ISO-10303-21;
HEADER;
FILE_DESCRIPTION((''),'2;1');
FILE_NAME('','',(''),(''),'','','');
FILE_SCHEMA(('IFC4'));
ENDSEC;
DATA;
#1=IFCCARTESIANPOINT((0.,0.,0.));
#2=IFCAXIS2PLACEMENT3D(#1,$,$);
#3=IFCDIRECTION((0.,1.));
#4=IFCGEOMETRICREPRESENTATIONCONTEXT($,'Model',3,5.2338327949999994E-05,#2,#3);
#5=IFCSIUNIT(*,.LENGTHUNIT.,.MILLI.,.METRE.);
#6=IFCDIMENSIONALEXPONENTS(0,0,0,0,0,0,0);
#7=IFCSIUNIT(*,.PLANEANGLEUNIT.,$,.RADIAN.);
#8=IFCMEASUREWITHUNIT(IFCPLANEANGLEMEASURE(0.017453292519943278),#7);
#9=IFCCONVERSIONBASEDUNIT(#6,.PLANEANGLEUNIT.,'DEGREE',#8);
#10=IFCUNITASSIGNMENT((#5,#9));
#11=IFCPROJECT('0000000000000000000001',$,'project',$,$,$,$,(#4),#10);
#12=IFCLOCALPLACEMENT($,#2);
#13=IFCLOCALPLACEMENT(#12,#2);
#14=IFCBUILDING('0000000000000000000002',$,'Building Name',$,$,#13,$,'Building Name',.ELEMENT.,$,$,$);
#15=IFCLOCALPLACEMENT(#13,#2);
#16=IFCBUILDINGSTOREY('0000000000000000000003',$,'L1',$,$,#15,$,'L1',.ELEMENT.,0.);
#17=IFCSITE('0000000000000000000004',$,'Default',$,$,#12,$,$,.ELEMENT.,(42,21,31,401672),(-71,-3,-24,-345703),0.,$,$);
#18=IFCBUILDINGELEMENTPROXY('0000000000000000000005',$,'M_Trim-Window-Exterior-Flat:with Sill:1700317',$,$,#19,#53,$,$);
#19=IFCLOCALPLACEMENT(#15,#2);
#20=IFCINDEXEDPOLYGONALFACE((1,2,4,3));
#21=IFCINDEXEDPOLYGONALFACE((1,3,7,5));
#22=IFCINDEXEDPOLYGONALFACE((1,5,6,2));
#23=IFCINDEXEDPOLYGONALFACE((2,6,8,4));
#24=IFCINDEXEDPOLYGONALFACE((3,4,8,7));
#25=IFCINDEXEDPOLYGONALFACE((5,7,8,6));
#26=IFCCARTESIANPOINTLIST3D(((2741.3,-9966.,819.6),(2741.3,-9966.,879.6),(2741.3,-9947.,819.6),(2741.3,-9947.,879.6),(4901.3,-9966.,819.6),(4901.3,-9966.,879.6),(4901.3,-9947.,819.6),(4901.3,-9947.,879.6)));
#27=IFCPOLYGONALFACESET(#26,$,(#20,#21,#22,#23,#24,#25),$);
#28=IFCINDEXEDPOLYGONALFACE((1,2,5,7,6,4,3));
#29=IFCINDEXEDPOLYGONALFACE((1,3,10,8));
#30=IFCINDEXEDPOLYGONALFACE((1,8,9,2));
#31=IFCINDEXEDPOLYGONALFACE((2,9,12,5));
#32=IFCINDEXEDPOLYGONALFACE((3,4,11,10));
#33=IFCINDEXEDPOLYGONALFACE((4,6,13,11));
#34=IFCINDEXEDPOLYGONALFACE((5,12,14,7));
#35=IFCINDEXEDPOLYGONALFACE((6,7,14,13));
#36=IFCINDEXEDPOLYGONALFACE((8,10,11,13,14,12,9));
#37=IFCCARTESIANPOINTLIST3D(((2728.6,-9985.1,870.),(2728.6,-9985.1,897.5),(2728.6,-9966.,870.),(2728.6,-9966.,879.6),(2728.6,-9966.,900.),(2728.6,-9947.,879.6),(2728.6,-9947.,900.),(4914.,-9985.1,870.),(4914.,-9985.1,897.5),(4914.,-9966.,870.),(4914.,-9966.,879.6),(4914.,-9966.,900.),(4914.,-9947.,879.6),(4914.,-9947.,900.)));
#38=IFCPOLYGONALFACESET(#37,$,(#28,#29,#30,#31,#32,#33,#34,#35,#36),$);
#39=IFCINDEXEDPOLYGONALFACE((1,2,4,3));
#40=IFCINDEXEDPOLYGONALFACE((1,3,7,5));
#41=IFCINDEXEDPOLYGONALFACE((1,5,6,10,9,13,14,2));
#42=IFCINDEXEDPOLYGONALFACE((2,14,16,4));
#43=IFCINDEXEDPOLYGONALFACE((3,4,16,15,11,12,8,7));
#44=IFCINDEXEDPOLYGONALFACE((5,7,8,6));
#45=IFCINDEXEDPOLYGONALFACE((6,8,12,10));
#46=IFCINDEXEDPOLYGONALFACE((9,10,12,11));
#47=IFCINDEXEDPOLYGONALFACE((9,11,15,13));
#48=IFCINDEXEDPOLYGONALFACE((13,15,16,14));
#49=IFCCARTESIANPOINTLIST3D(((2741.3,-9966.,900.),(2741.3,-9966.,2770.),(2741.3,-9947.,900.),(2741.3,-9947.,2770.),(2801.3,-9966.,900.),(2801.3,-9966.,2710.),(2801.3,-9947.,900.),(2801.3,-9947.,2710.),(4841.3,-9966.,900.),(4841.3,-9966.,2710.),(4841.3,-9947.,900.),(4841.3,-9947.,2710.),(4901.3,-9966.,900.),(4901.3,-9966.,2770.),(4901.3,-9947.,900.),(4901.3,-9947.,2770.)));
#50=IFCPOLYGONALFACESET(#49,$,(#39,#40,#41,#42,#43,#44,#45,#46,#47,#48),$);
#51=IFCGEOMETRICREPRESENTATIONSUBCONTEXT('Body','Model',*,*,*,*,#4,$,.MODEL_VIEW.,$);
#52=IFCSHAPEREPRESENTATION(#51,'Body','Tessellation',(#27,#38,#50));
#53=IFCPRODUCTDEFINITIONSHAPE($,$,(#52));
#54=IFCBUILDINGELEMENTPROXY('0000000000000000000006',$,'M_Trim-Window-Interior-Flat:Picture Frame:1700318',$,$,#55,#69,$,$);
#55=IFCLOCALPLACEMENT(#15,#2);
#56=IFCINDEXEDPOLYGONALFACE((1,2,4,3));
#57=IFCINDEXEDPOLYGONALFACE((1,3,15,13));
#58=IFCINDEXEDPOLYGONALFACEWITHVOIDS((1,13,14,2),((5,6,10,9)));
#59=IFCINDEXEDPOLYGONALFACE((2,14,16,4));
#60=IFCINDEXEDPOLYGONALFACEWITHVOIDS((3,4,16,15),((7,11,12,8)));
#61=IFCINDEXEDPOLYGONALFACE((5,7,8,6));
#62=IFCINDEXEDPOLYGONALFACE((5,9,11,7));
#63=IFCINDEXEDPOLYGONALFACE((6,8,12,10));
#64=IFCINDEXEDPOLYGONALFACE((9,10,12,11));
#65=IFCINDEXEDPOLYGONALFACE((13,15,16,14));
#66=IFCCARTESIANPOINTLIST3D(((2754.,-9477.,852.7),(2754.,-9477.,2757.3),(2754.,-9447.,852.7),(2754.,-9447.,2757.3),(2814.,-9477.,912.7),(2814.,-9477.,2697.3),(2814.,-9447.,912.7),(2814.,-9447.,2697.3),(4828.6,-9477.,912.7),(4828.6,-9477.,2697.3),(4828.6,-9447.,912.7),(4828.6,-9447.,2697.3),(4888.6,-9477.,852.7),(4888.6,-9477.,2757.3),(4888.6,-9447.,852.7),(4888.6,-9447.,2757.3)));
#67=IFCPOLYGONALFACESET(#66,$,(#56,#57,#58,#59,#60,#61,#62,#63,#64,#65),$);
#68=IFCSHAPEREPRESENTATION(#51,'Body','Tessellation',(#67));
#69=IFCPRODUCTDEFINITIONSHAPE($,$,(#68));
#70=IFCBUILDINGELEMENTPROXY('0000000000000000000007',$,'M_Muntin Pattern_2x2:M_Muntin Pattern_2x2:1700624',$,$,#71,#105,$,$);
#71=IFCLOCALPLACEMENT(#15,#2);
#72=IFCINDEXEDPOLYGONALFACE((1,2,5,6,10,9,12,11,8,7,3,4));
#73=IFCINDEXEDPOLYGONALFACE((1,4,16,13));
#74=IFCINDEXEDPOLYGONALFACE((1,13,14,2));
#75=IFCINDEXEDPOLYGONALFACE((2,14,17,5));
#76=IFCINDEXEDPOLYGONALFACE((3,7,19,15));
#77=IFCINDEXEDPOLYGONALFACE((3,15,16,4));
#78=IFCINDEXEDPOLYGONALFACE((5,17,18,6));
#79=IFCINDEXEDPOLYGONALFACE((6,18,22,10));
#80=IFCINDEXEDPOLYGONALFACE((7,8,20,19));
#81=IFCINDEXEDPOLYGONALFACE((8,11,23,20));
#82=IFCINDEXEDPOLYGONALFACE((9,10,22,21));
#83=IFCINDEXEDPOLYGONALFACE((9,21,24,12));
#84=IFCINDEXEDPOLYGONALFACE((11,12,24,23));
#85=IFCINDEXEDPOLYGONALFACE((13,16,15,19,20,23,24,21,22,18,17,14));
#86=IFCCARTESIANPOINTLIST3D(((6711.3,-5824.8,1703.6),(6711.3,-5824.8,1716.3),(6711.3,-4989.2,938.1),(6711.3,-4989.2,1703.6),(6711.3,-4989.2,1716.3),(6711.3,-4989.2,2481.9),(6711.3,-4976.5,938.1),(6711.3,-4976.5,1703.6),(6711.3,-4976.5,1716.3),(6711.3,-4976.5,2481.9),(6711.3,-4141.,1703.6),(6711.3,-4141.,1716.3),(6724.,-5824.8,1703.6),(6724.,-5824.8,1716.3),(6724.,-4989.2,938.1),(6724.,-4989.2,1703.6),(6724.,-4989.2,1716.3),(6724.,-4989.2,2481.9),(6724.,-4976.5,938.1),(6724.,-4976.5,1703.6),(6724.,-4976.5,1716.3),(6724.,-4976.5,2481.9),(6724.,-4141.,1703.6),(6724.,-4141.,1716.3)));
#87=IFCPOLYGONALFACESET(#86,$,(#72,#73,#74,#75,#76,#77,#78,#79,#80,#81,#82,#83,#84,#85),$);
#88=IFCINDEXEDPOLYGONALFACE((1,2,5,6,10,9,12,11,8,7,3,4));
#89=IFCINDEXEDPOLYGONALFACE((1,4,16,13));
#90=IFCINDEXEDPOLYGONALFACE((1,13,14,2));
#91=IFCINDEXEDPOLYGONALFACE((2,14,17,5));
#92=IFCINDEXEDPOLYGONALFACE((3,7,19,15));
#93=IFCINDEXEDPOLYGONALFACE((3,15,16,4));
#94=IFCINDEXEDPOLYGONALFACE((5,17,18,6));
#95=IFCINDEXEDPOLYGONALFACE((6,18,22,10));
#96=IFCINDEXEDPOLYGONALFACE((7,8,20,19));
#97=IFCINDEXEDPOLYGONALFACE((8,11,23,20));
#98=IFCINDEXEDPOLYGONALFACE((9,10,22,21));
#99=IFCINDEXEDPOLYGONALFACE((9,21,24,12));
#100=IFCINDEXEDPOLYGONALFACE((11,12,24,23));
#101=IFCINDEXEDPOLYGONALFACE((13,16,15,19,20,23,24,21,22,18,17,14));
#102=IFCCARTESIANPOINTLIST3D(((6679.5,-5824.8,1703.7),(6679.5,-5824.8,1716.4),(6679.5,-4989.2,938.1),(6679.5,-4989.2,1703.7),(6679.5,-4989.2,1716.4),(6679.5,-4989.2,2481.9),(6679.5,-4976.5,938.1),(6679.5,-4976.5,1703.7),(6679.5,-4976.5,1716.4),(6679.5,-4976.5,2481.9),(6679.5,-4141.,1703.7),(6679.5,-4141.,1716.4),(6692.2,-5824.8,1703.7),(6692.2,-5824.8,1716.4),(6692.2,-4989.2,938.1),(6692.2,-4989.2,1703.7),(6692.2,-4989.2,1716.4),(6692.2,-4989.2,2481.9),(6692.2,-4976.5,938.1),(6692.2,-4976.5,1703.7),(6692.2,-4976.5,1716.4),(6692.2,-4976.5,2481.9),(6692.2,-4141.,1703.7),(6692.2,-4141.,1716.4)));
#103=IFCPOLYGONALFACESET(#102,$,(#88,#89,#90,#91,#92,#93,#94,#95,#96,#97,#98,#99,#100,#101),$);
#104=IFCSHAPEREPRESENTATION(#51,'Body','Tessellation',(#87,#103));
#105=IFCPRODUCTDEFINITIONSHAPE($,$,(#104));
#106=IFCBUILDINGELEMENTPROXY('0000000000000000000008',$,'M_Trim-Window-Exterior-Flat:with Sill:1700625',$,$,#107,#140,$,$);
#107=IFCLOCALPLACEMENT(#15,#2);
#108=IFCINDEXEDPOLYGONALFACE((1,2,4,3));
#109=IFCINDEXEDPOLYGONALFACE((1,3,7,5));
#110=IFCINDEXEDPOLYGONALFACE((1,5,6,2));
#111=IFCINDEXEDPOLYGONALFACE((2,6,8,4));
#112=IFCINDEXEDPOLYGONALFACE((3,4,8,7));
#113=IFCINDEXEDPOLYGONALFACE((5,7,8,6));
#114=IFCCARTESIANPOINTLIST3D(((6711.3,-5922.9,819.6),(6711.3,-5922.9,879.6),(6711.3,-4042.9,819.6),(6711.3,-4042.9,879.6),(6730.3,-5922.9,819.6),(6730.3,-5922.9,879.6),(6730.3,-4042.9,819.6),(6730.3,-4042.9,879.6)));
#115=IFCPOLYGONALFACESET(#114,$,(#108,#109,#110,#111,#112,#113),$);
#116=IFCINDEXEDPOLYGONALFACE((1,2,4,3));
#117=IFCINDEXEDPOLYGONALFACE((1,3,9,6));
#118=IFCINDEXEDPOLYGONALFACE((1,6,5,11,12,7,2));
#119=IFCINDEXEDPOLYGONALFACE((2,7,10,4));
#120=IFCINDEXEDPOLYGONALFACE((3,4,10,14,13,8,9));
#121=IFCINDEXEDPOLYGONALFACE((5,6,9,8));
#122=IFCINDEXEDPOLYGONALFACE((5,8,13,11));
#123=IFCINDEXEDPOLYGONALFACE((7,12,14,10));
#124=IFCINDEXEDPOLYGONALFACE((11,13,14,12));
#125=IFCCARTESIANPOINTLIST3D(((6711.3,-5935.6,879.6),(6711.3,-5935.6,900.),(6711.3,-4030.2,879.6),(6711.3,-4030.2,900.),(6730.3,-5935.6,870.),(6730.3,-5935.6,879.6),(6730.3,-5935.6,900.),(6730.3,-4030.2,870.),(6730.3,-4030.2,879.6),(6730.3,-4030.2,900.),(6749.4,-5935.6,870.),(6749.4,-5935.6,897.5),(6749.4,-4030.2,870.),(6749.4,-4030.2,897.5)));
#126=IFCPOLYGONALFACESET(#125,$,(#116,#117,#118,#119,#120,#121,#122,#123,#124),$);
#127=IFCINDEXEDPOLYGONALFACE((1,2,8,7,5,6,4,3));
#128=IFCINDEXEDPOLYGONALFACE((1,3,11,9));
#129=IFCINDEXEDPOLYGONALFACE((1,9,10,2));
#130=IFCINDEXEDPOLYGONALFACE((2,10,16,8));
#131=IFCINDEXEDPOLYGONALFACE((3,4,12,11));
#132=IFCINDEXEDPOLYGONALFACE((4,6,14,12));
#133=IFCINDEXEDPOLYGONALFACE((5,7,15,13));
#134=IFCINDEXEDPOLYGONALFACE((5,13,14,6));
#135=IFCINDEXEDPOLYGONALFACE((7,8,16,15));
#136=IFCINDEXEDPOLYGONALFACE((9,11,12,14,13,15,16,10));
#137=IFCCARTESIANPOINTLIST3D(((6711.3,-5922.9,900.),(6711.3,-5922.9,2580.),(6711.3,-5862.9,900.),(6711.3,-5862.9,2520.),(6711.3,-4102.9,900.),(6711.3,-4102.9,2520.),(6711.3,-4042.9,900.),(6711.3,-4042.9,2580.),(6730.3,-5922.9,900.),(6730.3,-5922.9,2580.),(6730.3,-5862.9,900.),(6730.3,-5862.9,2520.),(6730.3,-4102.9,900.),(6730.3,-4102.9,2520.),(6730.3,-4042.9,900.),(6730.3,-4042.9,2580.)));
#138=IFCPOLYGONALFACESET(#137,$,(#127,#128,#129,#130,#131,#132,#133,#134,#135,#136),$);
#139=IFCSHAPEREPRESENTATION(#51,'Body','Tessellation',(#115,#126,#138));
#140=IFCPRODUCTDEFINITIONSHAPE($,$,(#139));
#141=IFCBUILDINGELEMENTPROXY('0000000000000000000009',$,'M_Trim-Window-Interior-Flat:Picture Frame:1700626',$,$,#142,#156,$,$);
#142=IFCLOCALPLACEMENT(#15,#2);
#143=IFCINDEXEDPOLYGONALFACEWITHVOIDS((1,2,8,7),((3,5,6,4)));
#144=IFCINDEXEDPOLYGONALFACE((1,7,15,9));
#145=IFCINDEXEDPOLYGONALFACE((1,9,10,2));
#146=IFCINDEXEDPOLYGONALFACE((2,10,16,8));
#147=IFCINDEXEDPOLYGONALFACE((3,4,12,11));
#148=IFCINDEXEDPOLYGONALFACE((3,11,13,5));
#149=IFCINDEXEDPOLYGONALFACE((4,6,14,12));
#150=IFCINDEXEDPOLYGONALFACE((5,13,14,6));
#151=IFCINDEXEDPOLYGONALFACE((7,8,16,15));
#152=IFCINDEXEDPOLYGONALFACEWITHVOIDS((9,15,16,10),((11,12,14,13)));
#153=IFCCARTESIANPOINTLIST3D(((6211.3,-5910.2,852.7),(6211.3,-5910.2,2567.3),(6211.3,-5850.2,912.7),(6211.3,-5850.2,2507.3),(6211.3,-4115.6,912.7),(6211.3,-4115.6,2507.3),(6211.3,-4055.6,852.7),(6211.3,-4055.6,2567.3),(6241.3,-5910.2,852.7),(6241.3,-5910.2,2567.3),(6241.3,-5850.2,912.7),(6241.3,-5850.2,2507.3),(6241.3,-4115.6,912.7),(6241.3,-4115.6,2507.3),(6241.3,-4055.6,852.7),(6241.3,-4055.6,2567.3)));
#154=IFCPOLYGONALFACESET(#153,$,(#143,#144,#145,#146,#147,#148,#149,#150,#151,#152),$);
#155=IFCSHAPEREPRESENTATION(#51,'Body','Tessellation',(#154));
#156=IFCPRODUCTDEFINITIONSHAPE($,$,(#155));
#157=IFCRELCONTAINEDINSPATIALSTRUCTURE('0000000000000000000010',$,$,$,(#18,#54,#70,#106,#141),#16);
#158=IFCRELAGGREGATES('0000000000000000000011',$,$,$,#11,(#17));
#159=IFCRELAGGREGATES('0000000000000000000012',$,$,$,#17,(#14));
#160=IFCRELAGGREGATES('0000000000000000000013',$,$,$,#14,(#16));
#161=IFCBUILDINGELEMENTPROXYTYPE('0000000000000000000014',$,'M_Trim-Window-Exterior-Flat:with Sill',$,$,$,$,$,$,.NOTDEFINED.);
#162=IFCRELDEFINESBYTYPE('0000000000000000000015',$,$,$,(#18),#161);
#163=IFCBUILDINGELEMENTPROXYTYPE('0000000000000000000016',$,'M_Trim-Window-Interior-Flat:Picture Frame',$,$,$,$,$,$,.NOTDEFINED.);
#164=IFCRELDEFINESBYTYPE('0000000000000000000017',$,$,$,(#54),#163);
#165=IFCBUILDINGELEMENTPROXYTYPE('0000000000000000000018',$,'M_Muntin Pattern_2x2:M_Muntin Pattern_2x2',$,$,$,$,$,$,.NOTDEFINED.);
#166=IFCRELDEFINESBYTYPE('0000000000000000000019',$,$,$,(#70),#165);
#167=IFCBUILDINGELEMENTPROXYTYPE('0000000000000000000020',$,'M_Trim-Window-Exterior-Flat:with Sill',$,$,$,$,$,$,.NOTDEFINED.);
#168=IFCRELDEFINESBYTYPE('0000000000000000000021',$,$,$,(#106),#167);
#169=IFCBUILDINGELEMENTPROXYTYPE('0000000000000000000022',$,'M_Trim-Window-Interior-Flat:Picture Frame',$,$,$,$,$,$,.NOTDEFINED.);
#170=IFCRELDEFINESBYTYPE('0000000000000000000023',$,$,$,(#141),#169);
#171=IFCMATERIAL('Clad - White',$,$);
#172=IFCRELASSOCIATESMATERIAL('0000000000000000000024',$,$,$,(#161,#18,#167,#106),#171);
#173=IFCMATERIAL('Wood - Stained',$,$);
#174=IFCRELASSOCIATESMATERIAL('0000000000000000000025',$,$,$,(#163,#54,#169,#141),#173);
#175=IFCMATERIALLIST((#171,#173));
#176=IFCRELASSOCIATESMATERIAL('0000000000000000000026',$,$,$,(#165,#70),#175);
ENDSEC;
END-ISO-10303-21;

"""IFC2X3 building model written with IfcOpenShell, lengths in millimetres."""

from ifc_helpers import new_model, entity, si_unit, converted_unit, direction, frame, frame_2d, origin, origin_2d_with_axis, place, context, subcontext, project, spatial, polyline, rectangle, outline, extrude, source, transform, mapped, material, material_list, type_object, type_shapes, element, save


model = new_model("IFC2X3")

# Units and contexts
model_context = context("Model", 3, precision=5.2338327949999994e-05, world=origin(), true_north=direction((0.0, 1.0)))
body_context = subcontext(model_context, "Body", "Model", "MODEL_VIEW")
ifc_project = project(units=[si_unit("LENGTHUNIT", "METRE", prefix="MILLI"), converted_unit("PLANEANGLEUNIT", "DEGREE", entity("IfcPlaneAngleMeasure", 0.017453292519943278), si_unit("PLANEANGLEUNIT", "RADIAN"), dimensions=[0, 0, 0, 0, 0, 0, 0])], contexts=[model_context])

# Site, building, storey
site_placement = place(None, origin())
site = spatial("IfcSite", under=ifc_project, at=site_placement, Name="Default", CompositionType="ELEMENT", RefLatitude=(42, 21, 31, 401672), RefLongitude=(-71, -3, -24, -345703), RefElevation=0.0)
building_placement = place(site_placement, origin())
building = spatial("IfcBuilding", under=site, at=building_placement, Name="Building Name", LongName="Building Name", CompositionType="ELEMENT")
storey_placement = place(building_placement, origin())
storey = spatial("IfcBuildingStorey", under=building, at=storey_placement, Name="L1", LongName="L1", CompositionType="ELEMENT", Elevation=0.0)

# Building element proxies
ifc_material_1 = material(Name="Clad - White")
ifc_material_2 = material(Name="Wood - Stained")
ifc_material_list = material_list([ifc_material_1, ifc_material_2])
building_element_proxy_type_1 = type_object("IfcBuildingElementProxyType", Name="M_Trim-Window-Exterior-Flat:with Sill", PredefinedType="NOTDEFINED", material=ifc_material_1)
shared_shape_1 = source(origin(), body_context, "Body", "SweptSolid", [
    extrude(rectangle(XDim=2160.0, YDim=60.0, at=frame_2d((0.0, 0.0), x_axis=(1.0, 0.0))), frame((0.0, -1860.4, 0.0), z_axis=(0.0, 0.0, 1.0), x_axis=(-1.0, 0.0, 0.0)), (0.0, 0.0, 1.0), 19.0),
    extrude(outline(polyline([(-19.0, -15.2), (0.0, -15.2), (0.0, -5.7), (19.0, -5.7), (19.0, 14.8), (0.0, 14.8), (-19.0, 12.3), (-19.0, -15.2)])), frame((-1092.7, -1824.8, 19.0), z_axis=(1.0, 0.0, 0.0), x_axis=(0.0, 0.0, -1.0)), (0.0, 0.0, 1.0), 2185.4),
    extrude(outline(polyline([(-950.0, -1080.0), (920.0, -1080.0), (920.0, -1020.0), (-890.0, -1020.0), (-890.0, 1020.0), (920.0, 1020.0), (920.0, 1080.0), (-950.0, 1080.0), (-950.0, -1080.0)])), frame((0.0, -890.0, 0.0), z_axis=(0.0, 0.0, 1.0), x_axis=(0.0, -1.0, 0.0)), (0.0, 0.0, 1.0), 19.0),
])
type_shapes(building_element_proxy_type_1, [shared_shape_1])
proxy_1_placement = place(storey_placement, frame((3821.3, -9947.0, 2710.0), z_axis=(0.0, -1.0, 0.0), x_axis=(1.0, 0.0, 0.0)))
element("IfcBuildingElementProxy", 1, at=proxy_1_placement, inside=storey, type_object=building_element_proxy_type_1, material=ifc_material_1, Name="M_Trim-Window-Exterior-Flat:with Sill:1700317", context=body_context, shape_type="MappedRepresentation", body=[
    mapped(shared_shape_1, transform((0.0, 0.0, 0.0), scale=1.0)),
])
building_element_proxy_type_2 = type_object("IfcBuildingElementProxyType", Name="M_Trim-Window-Interior-Flat:Picture Frame", PredefinedType="NOTDEFINED", material=ifc_material_2)
shared_shape_2 = source(origin(), body_context, "Body", "SweptSolid", [
    extrude(outline(polyline([(-1067.3, -952.3), (1067.3, -952.3), (1067.3, 952.3), (-1067.3, 952.3), (-1067.3, -952.3)]), holes=[polyline([(-1007.3, -892.3), (-1007.3, 892.3), (1007.3, 892.3), (1007.3, -892.3), (-1007.3, -892.3)])]), frame((0.0, -905.0, 0.0), z_axis=(0.0, 0.0, 1.0), x_axis=(-1.0, 0.0, 0.0)), (0.0, 0.0, 1.0), 30.0),
])
type_shapes(building_element_proxy_type_2, [shared_shape_2])
proxy_2_placement = place(storey_placement, frame((3821.3, -9477.0, 2710.0), z_axis=(0.0, 1.0, 0.0), x_axis=(-1.0, 0.0, 0.0)))
element("IfcBuildingElementProxy", 2, at=proxy_2_placement, inside=storey, type_object=building_element_proxy_type_2, material=ifc_material_2, Name="M_Trim-Window-Interior-Flat:Picture Frame:1700318", context=body_context, shape_type="MappedRepresentation", body=[
    mapped(shared_shape_2, transform((0.0, 0.0, 0.0), scale=1.0)),
])
building_element_proxy_type_3 = type_object("IfcBuildingElementProxyType", Name="M_Muntin Pattern_2x2:M_Muntin Pattern_2x2", PredefinedType="NOTDEFINED", material=ifc_material_list)
shared_shape_3 = source(origin(), body_context, "Body", "SweptSolid", [
    extrude(outline(polyline([(6.4, -6.4), (771.9, -6.4), (771.9, 6.3), (6.4, 6.3), (6.4, 841.9), (-6.3, 841.9), (-6.3, 6.3), (-771.9, 6.3), (-771.9, -6.4), (-6.3, -6.4), (-6.3, -841.9), (6.4, -841.9), (6.4, -6.4)])), frame((0.0, -22.2, 771.9), z_axis=(0.0, 1.0, 0.0), x_axis=(0.0, 0.0, 1.0)), (0.0, 0.0, 1.0), 12.7),
    extrude(outline(polyline([(6.4, -6.4), (771.9, -6.4), (771.9, 6.3), (6.4, 6.3), (6.4, 841.9), (-6.3, 841.9), (-6.3, 6.3), (-771.9, 6.3), (-771.9, -6.4), (-6.3, -6.4), (-6.3, -841.9), (6.4, -841.9), (6.4, -6.4)])), frame((0.0, 9.5, 771.9), z_axis=(0.0, 1.0, 0.0), x_axis=(0.0, 0.0, 1.0)), (0.0, 0.0, 1.0), 12.7),
])
type_shapes(building_element_proxy_type_3, [shared_shape_3])
proxy_3_placement = place(storey_placement, frame((6701.7, -4982.9, 938.1), z_axis=(0.0, 0.0, 1.0), x_axis=(0.0, 1.0, 0.0)))
element("IfcBuildingElementProxy", 3, at=proxy_3_placement, inside=storey, type_object=building_element_proxy_type_3, material=ifc_material_list, Name="M_Muntin Pattern_2x2:M_Muntin Pattern_2x2:1700624", context=body_context, shape_type="MappedRepresentation", body=[
    mapped(shared_shape_3, transform((0.0, 0.0, 0.0), scale=1.0)),
])
building_element_proxy_type_4 = type_object("IfcBuildingElementProxyType", Name="M_Trim-Window-Exterior-Flat:with Sill", PredefinedType="NOTDEFINED", material=ifc_material_1)
shared_shape_4 = source(origin(), body_context, "Body", "SweptSolid", [
    extrude(rectangle(XDim=1880.0, YDim=60.0, at=origin_2d_with_axis()), frame((0.0, -1670.4, 0.0), z_axis=(0.0, 0.0, 1.0), x_axis=(-1.0, 0.0, 0.0)), (0.0, 0.0, 1.0), 19.0),
    extrude(outline(polyline([(-19.0, -15.2), (0.0, -15.2), (0.0, -5.7), (19.0, -5.7), (19.0, 14.8), (0.0, 14.8), (-19.0, 12.3), (-19.0, -15.2)])), frame((-952.7, -1634.8, 19.0), z_axis=(1.0, 0.0, 0.0), x_axis=(0.0, 0.0, -1.0)), (0.0, 0.0, 1.0), 1905.4),
    extrude(outline(polyline([(-855.0, -940.0), (825.0, -940.0), (825.0, -880.0), (-795.0, -880.0), (-795.0, 880.0), (825.0, 880.0), (825.0, 940.0), (-855.0, 940.0), (-855.0, -940.0)])), frame((0.0, -795.0, 0.0), z_axis=(0.0, 0.0, 1.0), x_axis=(0.0, -1.0, 0.0)), (0.0, 0.0, 1.0), 19.0),
])
type_shapes(building_element_proxy_type_4, [shared_shape_4])
proxy_4_placement = place(storey_placement, frame((6711.3, -4982.9, 2520.0), z_axis=(1.0, 0.0, 0.0), x_axis=(0.0, 1.0, 0.0)))
element("IfcBuildingElementProxy", 4, at=proxy_4_placement, inside=storey, type_object=building_element_proxy_type_4, material=ifc_material_1, Name="M_Trim-Window-Exterior-Flat:with Sill:1700625", context=body_context, shape_type="MappedRepresentation", body=[
    mapped(shared_shape_4, transform((0.0, 0.0, 0.0), scale=1.0)),
])
building_element_proxy_type_5 = type_object("IfcBuildingElementProxyType", Name="M_Trim-Window-Interior-Flat:Picture Frame", PredefinedType="NOTDEFINED", material=ifc_material_2)
shared_shape_5 = source(origin(), body_context, "Body", "SweptSolid", [
    extrude(outline(polyline([(-927.3, -857.3), (927.3, -857.3), (927.3, 857.3), (-927.3, 857.3), (-927.3, -857.3)]), holes=[polyline([(-867.3, -797.3), (-867.3, 797.3), (867.3, 797.3), (867.3, -797.3), (-867.3, -797.3)])]), frame((0.0, -810.0, 0.0), z_axis=(0.0, 0.0, 1.0), x_axis=(-1.0, 0.0, 0.0)), (0.0, 0.0, 1.0), 30.0),
])
type_shapes(building_element_proxy_type_5, [shared_shape_5])
proxy_5_placement = place(storey_placement, frame((6241.3, -4982.9, 2520.0), z_axis=(-1.0, 0.0, 0.0), x_axis=(0.0, -1.0, 0.0)))
element("IfcBuildingElementProxy", 5, at=proxy_5_placement, inside=storey, type_object=building_element_proxy_type_5, material=ifc_material_2, Name="M_Trim-Window-Interior-Flat:Picture Frame:1700626", context=body_context, shape_type="MappedRepresentation", body=[
    mapped(shared_shape_5, transform((0.0, 0.0, 0.0), scale=1.0)),
])

save(model, "model.ifc")
